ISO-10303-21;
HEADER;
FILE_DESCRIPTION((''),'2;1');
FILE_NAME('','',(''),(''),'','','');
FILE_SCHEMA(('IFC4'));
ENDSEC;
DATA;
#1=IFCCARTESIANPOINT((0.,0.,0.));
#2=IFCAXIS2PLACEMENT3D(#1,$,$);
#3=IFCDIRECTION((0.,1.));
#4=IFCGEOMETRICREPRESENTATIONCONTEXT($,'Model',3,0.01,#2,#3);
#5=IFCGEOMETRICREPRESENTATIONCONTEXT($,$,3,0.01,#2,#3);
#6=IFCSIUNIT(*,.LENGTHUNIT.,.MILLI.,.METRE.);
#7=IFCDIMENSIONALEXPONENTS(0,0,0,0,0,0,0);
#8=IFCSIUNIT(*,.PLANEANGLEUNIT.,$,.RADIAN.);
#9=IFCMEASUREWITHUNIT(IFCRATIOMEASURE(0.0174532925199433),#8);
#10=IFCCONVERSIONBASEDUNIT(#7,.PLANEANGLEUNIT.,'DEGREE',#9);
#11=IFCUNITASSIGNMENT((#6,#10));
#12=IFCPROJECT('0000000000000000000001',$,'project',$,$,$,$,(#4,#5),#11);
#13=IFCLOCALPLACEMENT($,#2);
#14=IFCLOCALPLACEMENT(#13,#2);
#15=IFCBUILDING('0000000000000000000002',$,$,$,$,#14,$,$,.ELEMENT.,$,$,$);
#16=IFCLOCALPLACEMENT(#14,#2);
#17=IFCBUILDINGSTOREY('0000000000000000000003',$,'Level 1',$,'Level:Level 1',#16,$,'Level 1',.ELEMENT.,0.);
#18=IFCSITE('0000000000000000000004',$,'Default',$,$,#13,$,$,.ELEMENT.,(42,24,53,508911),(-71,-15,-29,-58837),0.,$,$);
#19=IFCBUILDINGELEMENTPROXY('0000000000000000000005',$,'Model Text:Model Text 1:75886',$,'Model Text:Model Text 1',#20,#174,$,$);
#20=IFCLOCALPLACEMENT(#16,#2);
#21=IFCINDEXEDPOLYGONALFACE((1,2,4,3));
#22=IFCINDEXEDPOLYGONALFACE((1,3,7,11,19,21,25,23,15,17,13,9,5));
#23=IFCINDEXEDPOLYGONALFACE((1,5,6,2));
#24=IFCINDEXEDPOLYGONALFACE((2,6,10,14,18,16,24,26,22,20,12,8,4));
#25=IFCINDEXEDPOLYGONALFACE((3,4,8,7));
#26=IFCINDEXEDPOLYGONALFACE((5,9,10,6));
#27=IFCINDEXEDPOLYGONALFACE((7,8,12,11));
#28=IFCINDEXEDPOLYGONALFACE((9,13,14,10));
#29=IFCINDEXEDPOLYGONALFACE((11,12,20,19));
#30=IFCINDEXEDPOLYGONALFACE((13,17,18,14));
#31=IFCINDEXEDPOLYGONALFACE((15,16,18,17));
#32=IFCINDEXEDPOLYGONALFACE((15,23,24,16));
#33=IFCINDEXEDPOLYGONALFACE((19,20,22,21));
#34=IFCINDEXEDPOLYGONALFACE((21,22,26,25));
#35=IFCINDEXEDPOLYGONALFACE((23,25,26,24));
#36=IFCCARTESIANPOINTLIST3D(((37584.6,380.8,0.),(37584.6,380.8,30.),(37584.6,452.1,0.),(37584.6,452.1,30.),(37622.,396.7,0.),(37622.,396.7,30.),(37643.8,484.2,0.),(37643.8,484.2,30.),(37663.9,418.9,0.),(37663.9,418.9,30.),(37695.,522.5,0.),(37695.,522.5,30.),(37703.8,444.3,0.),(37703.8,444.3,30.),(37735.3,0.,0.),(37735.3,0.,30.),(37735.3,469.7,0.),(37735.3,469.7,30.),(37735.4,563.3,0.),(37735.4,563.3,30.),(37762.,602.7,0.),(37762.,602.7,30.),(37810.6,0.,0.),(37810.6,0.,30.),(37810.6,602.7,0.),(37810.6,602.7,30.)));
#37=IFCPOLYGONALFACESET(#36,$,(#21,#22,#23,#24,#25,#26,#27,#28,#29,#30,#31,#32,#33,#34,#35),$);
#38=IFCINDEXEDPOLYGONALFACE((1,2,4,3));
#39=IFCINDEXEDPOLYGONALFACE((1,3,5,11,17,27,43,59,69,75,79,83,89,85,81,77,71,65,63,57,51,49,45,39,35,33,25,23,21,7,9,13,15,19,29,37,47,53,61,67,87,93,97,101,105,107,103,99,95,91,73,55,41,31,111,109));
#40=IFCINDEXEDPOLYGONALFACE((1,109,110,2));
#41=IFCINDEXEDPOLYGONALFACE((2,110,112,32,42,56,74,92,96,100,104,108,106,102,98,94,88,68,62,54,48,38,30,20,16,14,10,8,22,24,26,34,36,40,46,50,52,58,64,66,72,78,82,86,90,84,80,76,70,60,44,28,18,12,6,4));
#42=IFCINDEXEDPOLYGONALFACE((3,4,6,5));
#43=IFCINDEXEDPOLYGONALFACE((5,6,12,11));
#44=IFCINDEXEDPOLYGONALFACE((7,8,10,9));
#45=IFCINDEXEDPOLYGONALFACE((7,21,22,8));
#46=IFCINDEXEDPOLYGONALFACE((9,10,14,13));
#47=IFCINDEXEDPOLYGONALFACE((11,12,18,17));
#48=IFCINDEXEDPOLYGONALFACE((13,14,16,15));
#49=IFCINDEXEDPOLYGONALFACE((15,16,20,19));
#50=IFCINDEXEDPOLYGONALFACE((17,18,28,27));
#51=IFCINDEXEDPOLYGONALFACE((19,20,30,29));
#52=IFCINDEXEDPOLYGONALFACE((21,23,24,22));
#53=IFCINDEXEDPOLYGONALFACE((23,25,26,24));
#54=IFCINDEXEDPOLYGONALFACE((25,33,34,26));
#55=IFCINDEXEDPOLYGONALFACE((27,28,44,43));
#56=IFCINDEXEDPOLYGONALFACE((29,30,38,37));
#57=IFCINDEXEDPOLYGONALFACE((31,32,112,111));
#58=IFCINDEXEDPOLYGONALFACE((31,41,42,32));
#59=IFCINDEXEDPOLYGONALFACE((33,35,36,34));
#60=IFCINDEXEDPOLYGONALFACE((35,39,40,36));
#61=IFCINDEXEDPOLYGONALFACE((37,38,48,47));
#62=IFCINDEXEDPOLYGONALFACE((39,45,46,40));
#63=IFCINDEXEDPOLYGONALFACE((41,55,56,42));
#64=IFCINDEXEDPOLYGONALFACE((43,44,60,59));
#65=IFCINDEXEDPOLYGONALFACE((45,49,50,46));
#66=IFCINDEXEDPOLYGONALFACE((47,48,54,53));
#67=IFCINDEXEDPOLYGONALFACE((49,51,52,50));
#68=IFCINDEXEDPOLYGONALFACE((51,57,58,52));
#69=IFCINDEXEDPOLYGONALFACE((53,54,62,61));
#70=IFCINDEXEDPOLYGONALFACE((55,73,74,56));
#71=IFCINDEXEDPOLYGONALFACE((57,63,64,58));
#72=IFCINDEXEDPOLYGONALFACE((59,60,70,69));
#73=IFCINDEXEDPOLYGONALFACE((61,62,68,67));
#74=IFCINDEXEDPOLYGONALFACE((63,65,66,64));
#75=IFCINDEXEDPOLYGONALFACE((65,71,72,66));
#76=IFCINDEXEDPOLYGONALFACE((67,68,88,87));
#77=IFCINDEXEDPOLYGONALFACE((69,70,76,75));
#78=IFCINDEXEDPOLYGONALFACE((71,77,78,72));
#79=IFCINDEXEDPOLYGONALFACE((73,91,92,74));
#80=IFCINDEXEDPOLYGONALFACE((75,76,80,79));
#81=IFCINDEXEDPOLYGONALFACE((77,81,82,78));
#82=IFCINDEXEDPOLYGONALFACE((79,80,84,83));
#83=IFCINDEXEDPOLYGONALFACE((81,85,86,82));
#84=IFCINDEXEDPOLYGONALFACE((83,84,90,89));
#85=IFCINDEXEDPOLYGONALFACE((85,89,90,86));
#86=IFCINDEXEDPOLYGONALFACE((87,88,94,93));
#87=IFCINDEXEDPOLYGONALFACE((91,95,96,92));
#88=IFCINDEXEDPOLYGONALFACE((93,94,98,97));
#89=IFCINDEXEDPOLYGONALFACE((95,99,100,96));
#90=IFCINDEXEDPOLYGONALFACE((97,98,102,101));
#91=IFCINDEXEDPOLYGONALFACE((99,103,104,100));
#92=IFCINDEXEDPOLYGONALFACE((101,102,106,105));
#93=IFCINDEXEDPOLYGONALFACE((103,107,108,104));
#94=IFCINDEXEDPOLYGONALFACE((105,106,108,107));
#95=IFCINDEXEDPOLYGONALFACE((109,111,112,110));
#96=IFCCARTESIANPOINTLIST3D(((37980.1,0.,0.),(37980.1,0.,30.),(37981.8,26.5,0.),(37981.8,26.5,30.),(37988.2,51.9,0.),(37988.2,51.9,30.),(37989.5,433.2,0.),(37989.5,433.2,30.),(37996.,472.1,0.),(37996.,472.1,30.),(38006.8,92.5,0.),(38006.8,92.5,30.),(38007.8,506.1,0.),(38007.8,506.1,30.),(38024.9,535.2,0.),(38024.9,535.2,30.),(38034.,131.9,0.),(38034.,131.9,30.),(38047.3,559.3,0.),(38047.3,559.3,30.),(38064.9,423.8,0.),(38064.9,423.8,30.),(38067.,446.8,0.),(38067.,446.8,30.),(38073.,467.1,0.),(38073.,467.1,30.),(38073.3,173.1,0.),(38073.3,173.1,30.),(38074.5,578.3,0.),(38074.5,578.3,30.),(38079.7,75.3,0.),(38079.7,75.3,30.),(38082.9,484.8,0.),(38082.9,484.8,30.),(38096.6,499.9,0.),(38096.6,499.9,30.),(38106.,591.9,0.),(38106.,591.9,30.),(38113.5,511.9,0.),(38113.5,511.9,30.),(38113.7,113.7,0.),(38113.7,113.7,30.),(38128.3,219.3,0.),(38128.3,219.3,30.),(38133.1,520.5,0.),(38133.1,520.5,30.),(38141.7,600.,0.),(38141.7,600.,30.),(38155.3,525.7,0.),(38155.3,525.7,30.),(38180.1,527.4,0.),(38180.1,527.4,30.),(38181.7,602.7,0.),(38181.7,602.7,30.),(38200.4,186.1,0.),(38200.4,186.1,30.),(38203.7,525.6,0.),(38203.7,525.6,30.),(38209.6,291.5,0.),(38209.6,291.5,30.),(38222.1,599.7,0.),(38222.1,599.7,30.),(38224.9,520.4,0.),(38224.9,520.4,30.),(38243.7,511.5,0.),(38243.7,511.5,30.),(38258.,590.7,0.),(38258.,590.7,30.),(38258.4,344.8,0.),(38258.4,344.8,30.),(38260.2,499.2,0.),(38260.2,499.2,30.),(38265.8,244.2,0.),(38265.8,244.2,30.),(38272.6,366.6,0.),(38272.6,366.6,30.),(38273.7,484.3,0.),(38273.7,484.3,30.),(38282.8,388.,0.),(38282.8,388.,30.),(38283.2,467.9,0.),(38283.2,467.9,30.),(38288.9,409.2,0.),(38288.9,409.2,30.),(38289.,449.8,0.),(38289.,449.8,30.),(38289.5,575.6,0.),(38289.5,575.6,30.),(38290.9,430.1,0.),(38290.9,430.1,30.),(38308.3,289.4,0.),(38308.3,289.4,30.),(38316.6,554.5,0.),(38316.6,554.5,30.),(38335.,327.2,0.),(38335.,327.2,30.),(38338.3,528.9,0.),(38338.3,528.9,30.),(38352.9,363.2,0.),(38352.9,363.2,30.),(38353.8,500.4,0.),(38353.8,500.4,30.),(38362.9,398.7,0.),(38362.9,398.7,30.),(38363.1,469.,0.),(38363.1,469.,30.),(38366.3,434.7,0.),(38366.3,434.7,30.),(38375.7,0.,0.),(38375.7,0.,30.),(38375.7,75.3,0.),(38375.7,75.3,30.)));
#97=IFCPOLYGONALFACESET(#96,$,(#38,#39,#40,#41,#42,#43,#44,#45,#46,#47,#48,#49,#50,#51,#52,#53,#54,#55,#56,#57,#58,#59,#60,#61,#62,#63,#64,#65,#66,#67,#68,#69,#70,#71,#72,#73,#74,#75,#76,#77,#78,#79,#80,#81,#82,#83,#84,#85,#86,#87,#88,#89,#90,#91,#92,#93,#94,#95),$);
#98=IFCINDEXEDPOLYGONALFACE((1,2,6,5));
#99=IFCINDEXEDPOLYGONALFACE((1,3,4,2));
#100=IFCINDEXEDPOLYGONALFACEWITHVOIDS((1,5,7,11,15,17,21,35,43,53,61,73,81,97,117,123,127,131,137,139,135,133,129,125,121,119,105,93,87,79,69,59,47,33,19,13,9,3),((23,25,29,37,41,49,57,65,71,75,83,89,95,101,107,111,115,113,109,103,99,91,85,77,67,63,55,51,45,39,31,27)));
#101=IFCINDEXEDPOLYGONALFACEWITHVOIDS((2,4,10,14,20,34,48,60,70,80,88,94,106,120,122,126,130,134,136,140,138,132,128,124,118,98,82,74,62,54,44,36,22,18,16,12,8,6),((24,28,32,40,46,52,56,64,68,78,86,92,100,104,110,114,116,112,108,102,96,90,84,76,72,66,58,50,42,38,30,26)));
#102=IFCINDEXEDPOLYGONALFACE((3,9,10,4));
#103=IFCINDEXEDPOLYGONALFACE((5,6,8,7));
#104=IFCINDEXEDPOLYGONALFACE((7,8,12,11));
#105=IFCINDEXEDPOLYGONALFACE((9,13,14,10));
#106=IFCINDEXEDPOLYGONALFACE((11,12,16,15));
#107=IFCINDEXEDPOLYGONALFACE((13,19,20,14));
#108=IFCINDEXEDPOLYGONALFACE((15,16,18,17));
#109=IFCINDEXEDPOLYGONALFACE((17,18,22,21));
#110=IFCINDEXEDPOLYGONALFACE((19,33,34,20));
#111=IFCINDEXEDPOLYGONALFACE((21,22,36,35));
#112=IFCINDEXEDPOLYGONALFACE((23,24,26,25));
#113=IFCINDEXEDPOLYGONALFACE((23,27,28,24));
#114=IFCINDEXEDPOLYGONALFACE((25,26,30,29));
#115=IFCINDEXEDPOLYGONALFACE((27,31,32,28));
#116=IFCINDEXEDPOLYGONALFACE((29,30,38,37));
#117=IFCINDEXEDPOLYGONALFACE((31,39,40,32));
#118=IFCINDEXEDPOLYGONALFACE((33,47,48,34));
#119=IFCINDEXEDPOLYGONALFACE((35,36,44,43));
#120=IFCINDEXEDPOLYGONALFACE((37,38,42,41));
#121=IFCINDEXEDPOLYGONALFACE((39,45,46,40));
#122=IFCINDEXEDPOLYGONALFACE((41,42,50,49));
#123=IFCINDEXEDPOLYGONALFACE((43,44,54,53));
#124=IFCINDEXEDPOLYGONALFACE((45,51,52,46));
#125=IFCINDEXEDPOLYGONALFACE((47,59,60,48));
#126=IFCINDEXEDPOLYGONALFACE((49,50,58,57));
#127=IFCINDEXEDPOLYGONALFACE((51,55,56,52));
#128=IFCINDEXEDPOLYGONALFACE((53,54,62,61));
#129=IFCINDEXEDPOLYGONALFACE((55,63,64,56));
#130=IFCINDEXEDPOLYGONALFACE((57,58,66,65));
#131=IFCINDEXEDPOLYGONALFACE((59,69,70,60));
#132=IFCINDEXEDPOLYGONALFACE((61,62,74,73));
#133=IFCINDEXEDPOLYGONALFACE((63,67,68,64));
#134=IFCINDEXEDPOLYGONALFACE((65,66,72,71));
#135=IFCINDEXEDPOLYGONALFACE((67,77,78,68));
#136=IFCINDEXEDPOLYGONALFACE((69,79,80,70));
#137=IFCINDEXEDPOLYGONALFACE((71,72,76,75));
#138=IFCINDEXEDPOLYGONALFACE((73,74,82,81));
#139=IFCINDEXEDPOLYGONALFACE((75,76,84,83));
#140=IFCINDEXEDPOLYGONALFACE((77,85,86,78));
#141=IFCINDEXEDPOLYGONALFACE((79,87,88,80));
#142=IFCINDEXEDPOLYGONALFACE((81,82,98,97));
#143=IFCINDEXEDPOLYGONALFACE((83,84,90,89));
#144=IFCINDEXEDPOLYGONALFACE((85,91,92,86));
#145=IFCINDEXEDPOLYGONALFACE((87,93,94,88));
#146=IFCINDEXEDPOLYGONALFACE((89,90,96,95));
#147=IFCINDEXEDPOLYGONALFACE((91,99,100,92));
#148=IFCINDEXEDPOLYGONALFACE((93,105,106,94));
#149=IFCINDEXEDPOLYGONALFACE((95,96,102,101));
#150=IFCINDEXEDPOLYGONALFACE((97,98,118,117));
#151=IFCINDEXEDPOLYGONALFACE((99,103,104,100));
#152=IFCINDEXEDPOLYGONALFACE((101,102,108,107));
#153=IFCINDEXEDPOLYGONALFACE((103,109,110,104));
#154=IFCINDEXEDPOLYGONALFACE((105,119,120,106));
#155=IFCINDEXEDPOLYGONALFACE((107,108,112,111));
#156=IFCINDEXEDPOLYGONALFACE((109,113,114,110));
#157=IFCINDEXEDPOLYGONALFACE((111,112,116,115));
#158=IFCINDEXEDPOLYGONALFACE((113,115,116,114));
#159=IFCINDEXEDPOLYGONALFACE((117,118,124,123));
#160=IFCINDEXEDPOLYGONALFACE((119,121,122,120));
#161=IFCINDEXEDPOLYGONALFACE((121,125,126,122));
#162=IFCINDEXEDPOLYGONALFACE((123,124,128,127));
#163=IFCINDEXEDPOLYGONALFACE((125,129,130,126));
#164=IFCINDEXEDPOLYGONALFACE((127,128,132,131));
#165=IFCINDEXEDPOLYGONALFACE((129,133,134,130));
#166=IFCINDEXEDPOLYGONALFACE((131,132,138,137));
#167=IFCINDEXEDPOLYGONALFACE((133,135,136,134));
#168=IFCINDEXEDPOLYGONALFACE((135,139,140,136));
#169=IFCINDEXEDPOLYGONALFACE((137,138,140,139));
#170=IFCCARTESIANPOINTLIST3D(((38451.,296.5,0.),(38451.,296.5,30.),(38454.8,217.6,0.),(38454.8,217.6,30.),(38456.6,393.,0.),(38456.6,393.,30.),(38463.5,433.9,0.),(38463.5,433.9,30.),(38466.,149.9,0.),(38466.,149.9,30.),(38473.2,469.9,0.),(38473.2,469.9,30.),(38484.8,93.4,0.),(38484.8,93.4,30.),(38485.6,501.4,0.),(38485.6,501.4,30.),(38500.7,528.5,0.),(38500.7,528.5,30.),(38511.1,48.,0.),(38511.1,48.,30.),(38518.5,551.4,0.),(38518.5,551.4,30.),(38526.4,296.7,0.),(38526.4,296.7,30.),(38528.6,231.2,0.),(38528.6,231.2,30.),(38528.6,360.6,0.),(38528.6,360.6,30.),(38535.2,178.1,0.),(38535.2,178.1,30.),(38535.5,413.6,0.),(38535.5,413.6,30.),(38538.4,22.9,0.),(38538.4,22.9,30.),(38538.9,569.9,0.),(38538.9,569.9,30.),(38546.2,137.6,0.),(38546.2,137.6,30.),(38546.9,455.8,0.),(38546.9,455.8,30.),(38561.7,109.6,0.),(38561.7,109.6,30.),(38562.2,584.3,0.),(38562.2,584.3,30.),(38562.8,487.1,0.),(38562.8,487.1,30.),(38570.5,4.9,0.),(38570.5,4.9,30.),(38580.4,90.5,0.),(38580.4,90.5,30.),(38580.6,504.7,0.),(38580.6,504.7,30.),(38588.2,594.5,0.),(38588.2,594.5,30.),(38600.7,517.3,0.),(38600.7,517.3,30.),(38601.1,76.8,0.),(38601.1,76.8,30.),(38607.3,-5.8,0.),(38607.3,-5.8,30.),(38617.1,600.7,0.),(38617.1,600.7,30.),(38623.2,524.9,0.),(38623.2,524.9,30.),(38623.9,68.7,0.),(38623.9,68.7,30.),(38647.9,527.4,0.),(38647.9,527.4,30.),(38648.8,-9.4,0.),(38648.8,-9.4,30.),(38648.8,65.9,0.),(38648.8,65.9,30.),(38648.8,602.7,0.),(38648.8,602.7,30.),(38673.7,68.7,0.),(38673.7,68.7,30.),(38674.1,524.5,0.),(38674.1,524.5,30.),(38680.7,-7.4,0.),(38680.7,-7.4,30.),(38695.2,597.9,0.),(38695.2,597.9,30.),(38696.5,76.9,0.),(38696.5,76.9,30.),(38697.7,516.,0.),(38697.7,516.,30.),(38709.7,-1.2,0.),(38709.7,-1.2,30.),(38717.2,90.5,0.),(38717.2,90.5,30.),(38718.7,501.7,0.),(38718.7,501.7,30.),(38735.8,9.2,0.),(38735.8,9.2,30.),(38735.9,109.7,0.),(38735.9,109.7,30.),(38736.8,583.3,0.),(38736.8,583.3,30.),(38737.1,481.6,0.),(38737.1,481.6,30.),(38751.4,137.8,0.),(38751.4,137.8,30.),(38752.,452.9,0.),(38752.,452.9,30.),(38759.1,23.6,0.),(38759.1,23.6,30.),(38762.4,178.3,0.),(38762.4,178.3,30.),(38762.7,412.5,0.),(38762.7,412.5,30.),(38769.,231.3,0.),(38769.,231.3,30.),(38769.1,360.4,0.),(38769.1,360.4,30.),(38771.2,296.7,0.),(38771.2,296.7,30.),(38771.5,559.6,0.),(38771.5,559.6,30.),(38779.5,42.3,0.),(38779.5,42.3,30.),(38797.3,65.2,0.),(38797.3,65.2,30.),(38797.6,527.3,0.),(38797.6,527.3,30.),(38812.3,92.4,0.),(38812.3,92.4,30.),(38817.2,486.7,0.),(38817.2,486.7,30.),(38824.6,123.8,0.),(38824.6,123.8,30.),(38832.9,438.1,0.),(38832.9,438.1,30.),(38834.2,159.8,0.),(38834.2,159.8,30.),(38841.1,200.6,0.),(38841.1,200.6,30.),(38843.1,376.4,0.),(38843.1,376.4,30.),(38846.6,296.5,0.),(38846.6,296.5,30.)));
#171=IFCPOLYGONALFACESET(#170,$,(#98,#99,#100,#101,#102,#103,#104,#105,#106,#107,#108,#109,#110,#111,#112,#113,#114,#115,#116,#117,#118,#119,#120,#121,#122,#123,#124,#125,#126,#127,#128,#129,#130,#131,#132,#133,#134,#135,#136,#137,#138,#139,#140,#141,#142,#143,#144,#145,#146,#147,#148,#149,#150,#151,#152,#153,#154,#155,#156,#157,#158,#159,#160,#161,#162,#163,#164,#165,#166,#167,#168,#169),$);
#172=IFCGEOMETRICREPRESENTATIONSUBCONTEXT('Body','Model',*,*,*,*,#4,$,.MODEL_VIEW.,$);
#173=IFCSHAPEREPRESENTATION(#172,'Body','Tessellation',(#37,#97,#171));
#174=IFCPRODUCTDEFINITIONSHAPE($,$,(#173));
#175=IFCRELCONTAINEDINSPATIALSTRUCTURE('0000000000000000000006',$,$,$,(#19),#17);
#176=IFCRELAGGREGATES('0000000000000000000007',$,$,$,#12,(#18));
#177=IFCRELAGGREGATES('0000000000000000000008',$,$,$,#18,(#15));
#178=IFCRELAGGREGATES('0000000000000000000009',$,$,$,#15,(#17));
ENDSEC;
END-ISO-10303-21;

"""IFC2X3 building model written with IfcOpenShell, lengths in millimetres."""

from ifc_helpers import new_model, entity, si_unit, converted_unit, direction, frame, origin, place, context, subcontext, project, spatial, polyline, outline, extrude, element, save


model = new_model("IFC2X3")

# Units and contexts
model_context = context("Model", 3, precision=0.01, world=origin(), true_north=direction((0.0, 1.0)))
context_of_model = context(None, 3, precision=0.01, world=origin(), true_north=direction((0.0, 1.0)))
body_context = subcontext(model_context, "Body", "Model", "MODEL_VIEW")
ifc_project = project(units=[si_unit("LENGTHUNIT", "METRE", prefix="MILLI"), converted_unit("PLANEANGLEUNIT", "DEGREE", entity("IfcRatioMeasure", 0.0174532925199433), si_unit("PLANEANGLEUNIT", "RADIAN"), dimensions=[0, 0, 0, 0, 0, 0, 0])], contexts=[model_context, context_of_model])

# Site, building, storey
site_placement = place(None, origin())
site = spatial("IfcSite", under=ifc_project, at=site_placement, Name="Default", CompositionType="ELEMENT", RefLatitude=(42, 24, 53, 508911), RefLongitude=(-71, -15, -29, -58837), RefElevation=0.0)
building_placement = place(site_placement, origin())
building = spatial("IfcBuilding", under=site, at=building_placement, CompositionType="ELEMENT")
storey_placement = place(building_placement, origin())
storey = spatial("IfcBuildingStorey", under=building, at=storey_placement, Name="Level 1", ObjectType="Level:Level 1", LongName="Level 1", CompositionType="ELEMENT", Elevation=0.0)

# Building element proxy
proxy_1_placement = place(storey_placement, origin())
element("IfcBuildingElementProxy", 1, at=proxy_1_placement, inside=storey, Name="Model Text:Model Text 1:75886", ObjectType="Model Text:Model Text 1", context=body_context, shape_type="SweptSolid", body=[
    extrude(outline(polyline([(-410.6, -111.6), (192.1, -111.6), (192.1, -63.1), (152.7, -36.4), (111.9, 4.0), (73.6, 55.2), (41.4, 114.4), (-29.8, 114.4), (-13.9, 77.0), (8.3, 35.1), (33.7, -4.8), (59.1, -36.3), (-410.6, -36.3), (-410.6, -111.6)])), frame((37699.0, 410.6, 0.0), z_axis=(0.0, 0.0, 1.0), x_axis=(0.0, 1.0, 0.0)), (0.0, 0.0, 1.0), 30.0),
    extrude(outline(polyline([(-190.2, -317.5), (-190.2, -392.8), (205.4, -392.8), (203.7, -366.3), (197.3, -340.9), (178.7, -300.3), (151.5, -260.9), (112.2, -219.7), (57.2, -173.6), (-24.1, -101.3), (-72.9, -48.0), (-87.1, -26.3), (-97.3, -4.8), (-103.4, 16.4), (-105.4, 37.3), (-103.5, 57.0), (-97.7, 75.0), (-88.2, 91.5), (-74.7, 106.4), (-58.2, 118.7), (-39.4, 127.5), (-18.2, 132.8), (5.4, 134.6), (30.2, 132.9), (52.4, 127.7), (72.0, 119.1), (88.9, 107.1), (102.6, 92.0), (112.5, 74.3), (118.5, 54.0), (120.6, 31.0), (196.0, 40.4), (189.5, 79.3), (177.7, 113.3), (160.6, 142.4), (138.2, 166.5), (111.0, 185.5), (79.5, 199.1), (43.8, 207.2), (3.8, 209.9), (-36.6, 206.9), (-72.5, 197.9), (-104.0, 182.8), (-131.1, 161.7), (-152.8, 136.1), (-168.3, 107.6), (-177.6, 76.2), (-180.8, 41.9), (-177.4, 5.8), (-167.4, -29.6), (-149.5, -65.6), (-122.8, -103.4), (-80.3, -148.6), (-14.9, -206.7), (71.8, -279.1), (105.8, -317.5), (-190.2, -317.5)])), frame((38185.5, 392.8, 0.0), z_axis=(0.0, 0.0, -1.0), x_axis=(-1.0, 0.0, 0.0)), (0.0, 0.0, -1.0), 30.0),
    extrude(outline(polyline([(-10.6, -198.7), (68.3, -198.7), (136.5, -190.7), (193.9, -174.7), (240.5, -150.6), (266.9, -124.4), (286.3, -93.2), (298.8, -57.0), (304.3, -15.7), (303.8, 16.2), (299.0, 45.5), (289.9, 72.1), (276.6, 96.0), (258.9, 117.3), (236.9, 136.2), (210.4, 152.5), (179.6, 166.3), (144.1, 177.6), (103.7, 186.3), (8.2, 196.4), (-71.8, 196.7), (-134.0, 189.4), (-183.3, 176.1), (-224.7, 158.4), (-258.2, 133.9), (-283.5, 100.3), (-300.1, 59.5), (-307.1, 13.4), (-306.6, -18.4), (-301.8, -47.5), (-292.8, -74.0), (-279.6, -97.9), (-262.0, -119.2), (-240.0, -138.1), (-213.6, -154.5), (-182.8, -168.4), (-147.3, -179.8), (-106.7, -188.6), (-10.6, -198.7)]), holes=[polyline([(-7.2, -123.5), (-71.0, -118.2), (-123.6, -108.8), (-165.2, -95.4), (-195.7, -78.0), (-212.4, -59.4), (-224.1, -38.7), (-230.6, -15.9), (-231.9, 8.9), (-227.8, 35.0), (-218.1, 58.1), (-202.8, 78.4), (-182.0, 95.8), (-152.6, 109.4), (-111.7, 118.1), (-59.4, 122.0), (4.4, 121.1), (69.6, 115.8), (122.2, 106.7), (162.2, 93.7), (189.5, 77.0), (207.7, 57.4), (220.4, 36.0), (227.5, 12.8), (229.1, -12.1), (225.2, -36.8), (215.9, -59.2), (201.3, -79.3), (181.4, -97.1), (152.6, -111.2), (111.6, -120.3), (58.3, -124.4), (-7.2, -123.5)])]), frame((38650.0, 295.3, 0.0), z_axis=(0.0, 0.0, 1.0), x_axis=(0.047515, -0.998871, 0.0)), (0.0, 0.0, 1.0), 30.0),
])

save(model, "model.ifc")
